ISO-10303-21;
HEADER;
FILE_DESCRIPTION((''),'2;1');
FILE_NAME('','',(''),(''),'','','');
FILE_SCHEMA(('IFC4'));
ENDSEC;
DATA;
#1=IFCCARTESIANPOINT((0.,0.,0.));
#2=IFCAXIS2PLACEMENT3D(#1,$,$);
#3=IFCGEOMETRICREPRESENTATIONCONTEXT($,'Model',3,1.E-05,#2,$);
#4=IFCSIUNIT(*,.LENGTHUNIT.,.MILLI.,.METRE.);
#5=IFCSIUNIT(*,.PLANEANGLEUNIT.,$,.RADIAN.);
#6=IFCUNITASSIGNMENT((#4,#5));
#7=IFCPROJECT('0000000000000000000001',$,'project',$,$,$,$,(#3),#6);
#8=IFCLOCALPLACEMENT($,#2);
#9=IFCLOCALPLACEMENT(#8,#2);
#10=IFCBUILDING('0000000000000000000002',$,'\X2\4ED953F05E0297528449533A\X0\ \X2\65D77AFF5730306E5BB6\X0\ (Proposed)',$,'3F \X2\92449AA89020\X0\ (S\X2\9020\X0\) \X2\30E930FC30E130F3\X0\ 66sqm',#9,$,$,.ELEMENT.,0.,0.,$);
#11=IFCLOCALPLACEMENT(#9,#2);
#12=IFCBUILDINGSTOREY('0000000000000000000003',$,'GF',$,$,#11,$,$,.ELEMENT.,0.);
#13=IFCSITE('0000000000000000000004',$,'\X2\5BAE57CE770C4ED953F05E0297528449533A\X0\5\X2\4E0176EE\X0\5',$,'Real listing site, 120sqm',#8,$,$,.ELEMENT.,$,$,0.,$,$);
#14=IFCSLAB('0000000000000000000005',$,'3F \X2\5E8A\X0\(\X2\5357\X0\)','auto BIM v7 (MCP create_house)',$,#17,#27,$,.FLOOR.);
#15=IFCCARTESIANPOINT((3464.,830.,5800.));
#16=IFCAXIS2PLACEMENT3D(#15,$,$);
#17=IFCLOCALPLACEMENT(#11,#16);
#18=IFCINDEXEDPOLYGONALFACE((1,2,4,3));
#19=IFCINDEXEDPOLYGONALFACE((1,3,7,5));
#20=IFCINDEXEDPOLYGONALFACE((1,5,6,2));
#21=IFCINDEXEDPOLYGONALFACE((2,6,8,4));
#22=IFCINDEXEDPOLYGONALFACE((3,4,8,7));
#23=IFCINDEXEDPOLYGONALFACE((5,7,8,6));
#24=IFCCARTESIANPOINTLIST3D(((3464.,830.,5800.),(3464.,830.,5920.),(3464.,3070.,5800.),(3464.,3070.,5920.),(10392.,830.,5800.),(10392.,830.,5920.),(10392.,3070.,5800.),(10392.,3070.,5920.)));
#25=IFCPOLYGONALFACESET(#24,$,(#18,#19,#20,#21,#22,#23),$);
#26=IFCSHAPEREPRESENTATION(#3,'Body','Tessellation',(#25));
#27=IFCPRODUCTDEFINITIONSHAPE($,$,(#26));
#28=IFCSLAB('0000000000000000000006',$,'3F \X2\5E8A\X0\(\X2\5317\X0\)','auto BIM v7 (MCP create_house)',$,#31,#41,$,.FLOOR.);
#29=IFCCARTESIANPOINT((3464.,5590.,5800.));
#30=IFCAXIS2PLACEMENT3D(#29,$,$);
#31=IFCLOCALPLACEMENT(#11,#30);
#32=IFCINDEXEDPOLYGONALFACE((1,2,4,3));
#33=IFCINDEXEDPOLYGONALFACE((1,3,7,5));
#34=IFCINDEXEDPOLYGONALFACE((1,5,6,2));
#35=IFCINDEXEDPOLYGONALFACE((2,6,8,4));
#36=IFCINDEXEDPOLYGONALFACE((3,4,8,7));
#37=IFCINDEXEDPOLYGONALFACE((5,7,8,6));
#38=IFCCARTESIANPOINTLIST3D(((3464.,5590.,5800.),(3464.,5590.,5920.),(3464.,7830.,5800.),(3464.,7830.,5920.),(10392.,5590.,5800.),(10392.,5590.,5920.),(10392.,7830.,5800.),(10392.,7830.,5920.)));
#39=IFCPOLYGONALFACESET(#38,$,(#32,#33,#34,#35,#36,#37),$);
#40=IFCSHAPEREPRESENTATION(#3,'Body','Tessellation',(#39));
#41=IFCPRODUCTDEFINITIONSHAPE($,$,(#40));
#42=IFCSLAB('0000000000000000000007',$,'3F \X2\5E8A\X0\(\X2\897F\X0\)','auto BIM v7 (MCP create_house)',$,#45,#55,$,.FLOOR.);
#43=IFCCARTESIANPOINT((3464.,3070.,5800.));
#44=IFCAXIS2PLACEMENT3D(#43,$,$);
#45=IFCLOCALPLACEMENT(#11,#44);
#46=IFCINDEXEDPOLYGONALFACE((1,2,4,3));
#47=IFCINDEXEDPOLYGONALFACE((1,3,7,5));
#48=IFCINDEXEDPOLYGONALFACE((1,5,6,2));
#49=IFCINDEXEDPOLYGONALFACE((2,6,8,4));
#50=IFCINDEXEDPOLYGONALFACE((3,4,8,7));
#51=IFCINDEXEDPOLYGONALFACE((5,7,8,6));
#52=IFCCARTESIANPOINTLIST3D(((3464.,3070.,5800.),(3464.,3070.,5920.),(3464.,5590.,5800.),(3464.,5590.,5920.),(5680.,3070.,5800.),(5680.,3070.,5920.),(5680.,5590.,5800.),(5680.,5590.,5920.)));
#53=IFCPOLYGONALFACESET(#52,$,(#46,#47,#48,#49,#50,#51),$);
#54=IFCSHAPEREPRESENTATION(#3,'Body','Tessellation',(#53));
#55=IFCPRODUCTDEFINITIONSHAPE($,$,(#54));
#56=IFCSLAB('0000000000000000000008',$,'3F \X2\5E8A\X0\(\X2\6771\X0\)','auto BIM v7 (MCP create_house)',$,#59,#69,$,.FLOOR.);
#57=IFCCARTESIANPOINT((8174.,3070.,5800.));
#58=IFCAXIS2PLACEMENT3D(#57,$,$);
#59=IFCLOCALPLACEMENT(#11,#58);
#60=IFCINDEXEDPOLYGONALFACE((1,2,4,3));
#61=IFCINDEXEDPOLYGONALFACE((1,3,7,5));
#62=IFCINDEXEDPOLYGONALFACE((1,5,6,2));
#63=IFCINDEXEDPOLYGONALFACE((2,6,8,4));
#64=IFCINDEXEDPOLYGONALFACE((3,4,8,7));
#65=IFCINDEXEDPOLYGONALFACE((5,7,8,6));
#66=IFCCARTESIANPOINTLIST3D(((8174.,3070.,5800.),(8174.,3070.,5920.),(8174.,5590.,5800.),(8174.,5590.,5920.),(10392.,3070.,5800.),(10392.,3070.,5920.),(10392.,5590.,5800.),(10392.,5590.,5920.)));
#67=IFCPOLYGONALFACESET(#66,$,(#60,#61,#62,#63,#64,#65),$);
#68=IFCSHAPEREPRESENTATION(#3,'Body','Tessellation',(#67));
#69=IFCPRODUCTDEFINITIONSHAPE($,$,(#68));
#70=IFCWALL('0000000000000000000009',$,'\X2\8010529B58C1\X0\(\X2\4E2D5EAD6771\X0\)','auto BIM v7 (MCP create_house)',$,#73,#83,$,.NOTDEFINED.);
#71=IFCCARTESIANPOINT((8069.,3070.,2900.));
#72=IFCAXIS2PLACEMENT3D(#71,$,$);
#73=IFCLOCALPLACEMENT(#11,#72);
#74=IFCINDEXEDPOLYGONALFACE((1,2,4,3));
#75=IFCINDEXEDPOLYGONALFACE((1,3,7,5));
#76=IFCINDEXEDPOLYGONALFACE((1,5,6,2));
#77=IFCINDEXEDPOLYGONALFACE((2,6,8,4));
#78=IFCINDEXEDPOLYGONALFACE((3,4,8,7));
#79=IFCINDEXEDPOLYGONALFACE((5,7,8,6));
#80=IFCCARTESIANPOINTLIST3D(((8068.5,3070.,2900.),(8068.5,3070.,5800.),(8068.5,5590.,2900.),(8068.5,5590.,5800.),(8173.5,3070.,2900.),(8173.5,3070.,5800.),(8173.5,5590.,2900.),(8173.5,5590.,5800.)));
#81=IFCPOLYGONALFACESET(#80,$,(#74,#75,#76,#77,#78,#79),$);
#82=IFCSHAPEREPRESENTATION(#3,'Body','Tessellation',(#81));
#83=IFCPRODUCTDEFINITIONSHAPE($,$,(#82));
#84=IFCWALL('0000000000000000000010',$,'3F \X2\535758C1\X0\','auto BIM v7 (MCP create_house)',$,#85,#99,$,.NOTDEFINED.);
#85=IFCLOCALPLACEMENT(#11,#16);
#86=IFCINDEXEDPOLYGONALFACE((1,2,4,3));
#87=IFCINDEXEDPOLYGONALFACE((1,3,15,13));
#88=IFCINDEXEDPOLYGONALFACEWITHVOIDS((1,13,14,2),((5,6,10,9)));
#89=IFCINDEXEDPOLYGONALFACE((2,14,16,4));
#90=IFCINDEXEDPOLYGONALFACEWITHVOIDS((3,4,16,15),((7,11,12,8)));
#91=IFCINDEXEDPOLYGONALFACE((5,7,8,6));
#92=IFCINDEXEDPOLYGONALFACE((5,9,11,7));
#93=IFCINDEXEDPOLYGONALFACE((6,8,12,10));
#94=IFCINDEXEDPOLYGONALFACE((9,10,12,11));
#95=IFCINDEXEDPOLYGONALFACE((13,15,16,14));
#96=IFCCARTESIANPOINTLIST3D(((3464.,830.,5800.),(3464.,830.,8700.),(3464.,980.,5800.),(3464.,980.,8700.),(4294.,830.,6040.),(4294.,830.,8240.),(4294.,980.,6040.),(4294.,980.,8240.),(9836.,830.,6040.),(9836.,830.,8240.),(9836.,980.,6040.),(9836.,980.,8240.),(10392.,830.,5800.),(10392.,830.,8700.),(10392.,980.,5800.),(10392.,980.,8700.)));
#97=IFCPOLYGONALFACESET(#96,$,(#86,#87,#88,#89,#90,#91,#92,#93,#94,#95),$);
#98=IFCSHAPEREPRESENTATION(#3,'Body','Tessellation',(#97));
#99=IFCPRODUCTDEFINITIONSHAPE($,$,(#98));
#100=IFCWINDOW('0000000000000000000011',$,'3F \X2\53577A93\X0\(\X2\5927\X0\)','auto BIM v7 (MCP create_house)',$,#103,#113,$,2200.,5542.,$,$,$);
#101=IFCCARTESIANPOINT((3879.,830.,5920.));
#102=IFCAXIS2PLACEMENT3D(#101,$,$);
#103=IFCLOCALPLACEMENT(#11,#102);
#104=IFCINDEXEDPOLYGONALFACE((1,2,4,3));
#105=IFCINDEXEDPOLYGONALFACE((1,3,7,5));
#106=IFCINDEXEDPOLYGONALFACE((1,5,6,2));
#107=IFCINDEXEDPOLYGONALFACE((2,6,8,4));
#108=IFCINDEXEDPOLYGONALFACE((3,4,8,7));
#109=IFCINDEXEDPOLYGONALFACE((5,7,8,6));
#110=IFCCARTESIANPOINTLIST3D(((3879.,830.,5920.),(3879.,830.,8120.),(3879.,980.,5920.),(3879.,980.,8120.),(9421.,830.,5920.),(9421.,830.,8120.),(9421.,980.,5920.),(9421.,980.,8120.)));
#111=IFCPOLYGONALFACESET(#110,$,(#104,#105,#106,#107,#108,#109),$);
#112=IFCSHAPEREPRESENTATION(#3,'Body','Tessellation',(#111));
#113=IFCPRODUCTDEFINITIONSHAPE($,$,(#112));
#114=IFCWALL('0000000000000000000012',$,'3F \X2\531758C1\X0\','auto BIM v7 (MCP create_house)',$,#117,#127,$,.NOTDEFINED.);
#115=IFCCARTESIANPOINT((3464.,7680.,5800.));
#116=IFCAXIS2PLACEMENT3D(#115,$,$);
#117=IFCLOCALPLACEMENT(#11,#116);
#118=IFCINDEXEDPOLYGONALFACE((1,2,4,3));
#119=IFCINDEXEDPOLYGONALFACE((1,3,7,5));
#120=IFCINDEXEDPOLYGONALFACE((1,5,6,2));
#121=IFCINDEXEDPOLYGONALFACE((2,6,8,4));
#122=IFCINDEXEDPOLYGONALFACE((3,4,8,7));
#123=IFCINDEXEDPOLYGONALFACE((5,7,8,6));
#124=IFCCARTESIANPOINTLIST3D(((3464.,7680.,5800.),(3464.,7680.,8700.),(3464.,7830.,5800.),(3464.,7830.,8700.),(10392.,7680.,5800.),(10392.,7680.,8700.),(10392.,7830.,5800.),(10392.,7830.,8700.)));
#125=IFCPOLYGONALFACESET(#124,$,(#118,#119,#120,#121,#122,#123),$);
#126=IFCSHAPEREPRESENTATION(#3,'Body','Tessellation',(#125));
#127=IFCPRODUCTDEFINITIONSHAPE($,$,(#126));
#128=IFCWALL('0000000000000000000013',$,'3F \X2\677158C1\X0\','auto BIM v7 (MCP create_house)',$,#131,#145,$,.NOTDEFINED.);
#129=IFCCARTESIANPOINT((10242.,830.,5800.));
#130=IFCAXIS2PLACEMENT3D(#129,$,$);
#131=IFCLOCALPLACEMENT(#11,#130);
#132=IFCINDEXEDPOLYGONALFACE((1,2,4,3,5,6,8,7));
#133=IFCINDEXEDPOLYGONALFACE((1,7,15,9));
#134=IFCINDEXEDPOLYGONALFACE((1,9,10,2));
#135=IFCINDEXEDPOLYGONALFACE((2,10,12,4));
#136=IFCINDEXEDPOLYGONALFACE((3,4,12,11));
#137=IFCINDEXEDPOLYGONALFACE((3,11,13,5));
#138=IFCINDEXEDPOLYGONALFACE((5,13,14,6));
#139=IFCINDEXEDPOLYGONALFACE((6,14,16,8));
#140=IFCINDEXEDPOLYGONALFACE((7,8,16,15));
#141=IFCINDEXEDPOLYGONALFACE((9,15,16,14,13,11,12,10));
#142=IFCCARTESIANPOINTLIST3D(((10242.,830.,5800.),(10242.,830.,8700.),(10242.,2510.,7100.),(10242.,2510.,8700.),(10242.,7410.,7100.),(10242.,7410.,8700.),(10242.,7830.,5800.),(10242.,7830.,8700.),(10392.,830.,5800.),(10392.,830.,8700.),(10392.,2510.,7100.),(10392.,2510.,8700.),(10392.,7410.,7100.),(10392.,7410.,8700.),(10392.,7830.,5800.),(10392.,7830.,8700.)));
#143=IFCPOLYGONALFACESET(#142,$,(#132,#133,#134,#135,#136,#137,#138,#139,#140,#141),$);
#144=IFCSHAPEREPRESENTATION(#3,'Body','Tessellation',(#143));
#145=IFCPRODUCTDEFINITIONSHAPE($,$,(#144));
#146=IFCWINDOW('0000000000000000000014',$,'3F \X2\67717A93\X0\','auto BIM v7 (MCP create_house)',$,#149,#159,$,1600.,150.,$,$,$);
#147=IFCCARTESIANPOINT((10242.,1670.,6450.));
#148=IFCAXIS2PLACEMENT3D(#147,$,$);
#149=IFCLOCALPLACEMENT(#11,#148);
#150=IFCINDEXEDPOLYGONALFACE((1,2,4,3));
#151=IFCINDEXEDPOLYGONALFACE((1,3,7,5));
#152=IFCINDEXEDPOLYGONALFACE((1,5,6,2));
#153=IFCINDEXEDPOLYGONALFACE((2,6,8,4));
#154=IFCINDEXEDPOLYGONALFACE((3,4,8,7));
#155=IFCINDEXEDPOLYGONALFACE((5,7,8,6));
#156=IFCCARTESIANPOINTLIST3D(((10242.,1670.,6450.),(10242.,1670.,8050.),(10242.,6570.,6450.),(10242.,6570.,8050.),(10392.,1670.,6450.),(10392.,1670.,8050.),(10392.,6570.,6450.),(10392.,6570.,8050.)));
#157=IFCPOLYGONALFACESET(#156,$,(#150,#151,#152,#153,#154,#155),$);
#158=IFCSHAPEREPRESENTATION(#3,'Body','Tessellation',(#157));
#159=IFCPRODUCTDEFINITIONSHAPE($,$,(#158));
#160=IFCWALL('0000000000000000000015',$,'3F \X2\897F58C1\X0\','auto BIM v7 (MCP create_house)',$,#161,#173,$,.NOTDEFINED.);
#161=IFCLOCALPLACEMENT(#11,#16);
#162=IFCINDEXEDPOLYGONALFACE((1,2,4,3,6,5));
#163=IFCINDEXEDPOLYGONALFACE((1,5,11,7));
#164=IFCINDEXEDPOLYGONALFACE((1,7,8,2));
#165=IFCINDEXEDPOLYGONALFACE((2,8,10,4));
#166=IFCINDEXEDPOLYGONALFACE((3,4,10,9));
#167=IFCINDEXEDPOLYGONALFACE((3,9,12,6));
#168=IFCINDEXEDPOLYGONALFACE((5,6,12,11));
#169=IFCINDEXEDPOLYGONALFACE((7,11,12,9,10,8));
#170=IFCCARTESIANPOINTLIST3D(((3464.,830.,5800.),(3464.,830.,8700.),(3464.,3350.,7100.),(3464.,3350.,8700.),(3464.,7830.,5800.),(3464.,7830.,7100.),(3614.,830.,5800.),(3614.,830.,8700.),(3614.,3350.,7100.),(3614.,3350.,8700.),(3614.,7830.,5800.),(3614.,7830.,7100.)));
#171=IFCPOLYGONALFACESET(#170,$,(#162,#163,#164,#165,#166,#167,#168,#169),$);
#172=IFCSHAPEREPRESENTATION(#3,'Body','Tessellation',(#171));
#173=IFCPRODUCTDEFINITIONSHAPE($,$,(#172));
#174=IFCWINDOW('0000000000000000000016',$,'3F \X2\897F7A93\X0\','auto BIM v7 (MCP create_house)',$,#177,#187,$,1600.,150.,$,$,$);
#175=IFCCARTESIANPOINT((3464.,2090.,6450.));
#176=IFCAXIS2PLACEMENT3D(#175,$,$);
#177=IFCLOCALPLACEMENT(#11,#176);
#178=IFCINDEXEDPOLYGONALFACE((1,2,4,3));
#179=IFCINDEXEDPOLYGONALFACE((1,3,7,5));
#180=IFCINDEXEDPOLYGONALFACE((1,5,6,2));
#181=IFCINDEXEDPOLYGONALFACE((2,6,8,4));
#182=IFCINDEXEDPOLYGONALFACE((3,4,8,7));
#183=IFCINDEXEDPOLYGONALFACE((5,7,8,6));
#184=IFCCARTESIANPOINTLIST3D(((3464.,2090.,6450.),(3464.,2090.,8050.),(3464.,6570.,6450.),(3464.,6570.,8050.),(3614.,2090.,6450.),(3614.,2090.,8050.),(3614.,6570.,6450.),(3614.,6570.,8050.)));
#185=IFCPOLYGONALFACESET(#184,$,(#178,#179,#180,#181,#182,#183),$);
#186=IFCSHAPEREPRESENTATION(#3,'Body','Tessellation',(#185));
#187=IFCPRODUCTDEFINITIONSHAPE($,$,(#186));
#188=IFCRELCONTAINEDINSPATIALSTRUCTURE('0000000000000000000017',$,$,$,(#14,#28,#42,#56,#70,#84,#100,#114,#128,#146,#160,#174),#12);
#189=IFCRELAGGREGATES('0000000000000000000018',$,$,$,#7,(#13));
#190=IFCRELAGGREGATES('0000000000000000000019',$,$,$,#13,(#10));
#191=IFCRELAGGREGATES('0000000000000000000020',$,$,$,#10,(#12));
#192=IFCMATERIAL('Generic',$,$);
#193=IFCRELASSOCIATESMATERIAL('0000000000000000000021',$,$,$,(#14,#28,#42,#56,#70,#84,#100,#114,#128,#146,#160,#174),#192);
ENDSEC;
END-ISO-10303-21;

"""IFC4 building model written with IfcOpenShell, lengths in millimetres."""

from ifc_helpers import new_model, si_unit, frame, frame_2d, origin, place, context, project, spatial, rectangle, extrude, material, element, fill, save


model = new_model("IFC4")

# Units and contexts
model_context = context("Model", 3, precision=1e-05, world=origin())
ifc_project = project(units=[si_unit("LENGTHUNIT", "METRE", prefix="MILLI"), si_unit("PLANEANGLEUNIT", "RADIAN")], contexts=[model_context])

# Site, building, storey
site_placement = place(None, origin())
site = spatial("IfcSite", under=ifc_project, at=site_placement, Name="宮城県仙台市青葉区5丁目5", ObjectType="Real listing site, 120sqm", CompositionType="ELEMENT", RefElevation=0.0)
building_placement = place(site_placement, origin())
building = spatial("IfcBuilding", under=site, at=building_placement, Name="仙台市青葉区 旗竿地の家 (Proposed)", ObjectType="3F 鉄骨造 (S造) ラーメン 66sqm", CompositionType="ELEMENT", ElevationOfRefHeight=0.0, ElevationOfTerrain=0.0)
storey_placement = place(building_placement, origin())
storey = spatial("IfcBuildingStorey", under=building, at=storey_placement, Name="GF", CompositionType="ELEMENT", Elevation=0.0)

# Slabs
ifc_material = material(Name="Generic")
slab_1_placement = place(storey_placement, frame((3464.0, 830.0, 5800.0)))
element("IfcSlab", 1, at=slab_1_placement, inside=storey, material=ifc_material, Name="3F 床(南)", Description="auto BIM v7 (MCP create_house)", PredefinedType="FLOOR", context=model_context, shape_type="SweptSolid", body=[
    extrude(rectangle(XDim=6928.0, YDim=2240.0, at=frame_2d((3464.0, 1120.0))), frame((3464.0, 830.0, 5800.0)), (0.0, 0.0, 1.0), 120.0),
])
slab_2_placement = place(storey_placement, frame((3464.0, 5590.0, 5800.0)))
element("IfcSlab", 2, at=slab_2_placement, inside=storey, material=ifc_material, Name="3F 床(北)", Description="auto BIM v7 (MCP create_house)", PredefinedType="FLOOR", context=model_context, shape_type="SweptSolid", body=[
    extrude(rectangle(XDim=6928.0, YDim=2240.0, at=frame_2d((3464.0, 1120.0))), frame((3464.0, 5590.0, 5800.0)), (0.0, 0.0, 1.0), 120.0),
])
slab_3_placement = place(storey_placement, frame((3464.0, 3070.0, 5800.0)))
element("IfcSlab", 3, at=slab_3_placement, inside=storey, material=ifc_material, Name="3F 床(西)", Description="auto BIM v7 (MCP create_house)", PredefinedType="FLOOR", context=model_context, shape_type="SweptSolid", body=[
    extrude(rectangle(XDim=2216.0, YDim=2520.0, at=frame_2d((1108.0, 1260.0))), frame((3464.0, 3070.0, 5800.0)), (0.0, 0.0, 1.0), 120.0),
])
slab_4_placement = place(storey_placement, frame((8174.0, 3070.0, 5800.0)))
element("IfcSlab", 4, at=slab_4_placement, inside=storey, material=ifc_material, Name="3F 床(東)", Description="auto BIM v7 (MCP create_house)", PredefinedType="FLOOR", context=model_context, shape_type="SweptSolid", body=[
    extrude(rectangle(XDim=2218.0, YDim=2520.0, at=frame_2d((1109.0, 1260.0))), frame((8174.0, 3070.0, 5800.0)), (0.0, 0.0, 1.0), 120.0),
])

# Wall
wall_1_placement = place(storey_placement, frame((8069.0, 3070.0, 2900.0)))
element("IfcWall", 5, at=wall_1_placement, inside=storey, material=ifc_material, Name="耐力壁(中庭東)", Description="auto BIM v7 (MCP create_house)", PredefinedType="NOTDEFINED", context=model_context, shape_type="SweptSolid", body=[
    extrude(rectangle(XDim=105.0, YDim=2520.0, at=frame_2d((52.0, 1260.0))), frame((8069.0, 3070.0, 2900.0)), (0.0, 0.0, 1.0), 2900.0),
])

# Wall, opening, window
wall_2_placement = place(storey_placement, frame((3464.0, 830.0, 5800.0)))
wall_2 = element("IfcWall", 6, at=wall_2_placement, inside=storey, material=ifc_material, Name="3F 南壁", Description="auto BIM v7 (MCP create_house)", PredefinedType="NOTDEFINED", context=model_context, shape_type="SweptSolid", body=[
    extrude(rectangle(XDim=6928.0, YDim=150.0, at=frame_2d((3464.0, 75.0))), frame((3464.0, 830.0, 5800.0)), (0.0, 0.0, 1.0), 2900.0),
])
opening_1_placement = place(storey_placement, frame((3879.0, 830.0, 5920.0)))
opening_1 = element("IfcOpeningElement", 7, at=opening_1_placement, cuts=wall_2, PredefinedType="NOTDEFINED", context=model_context, shape_type="SweptSolid", body=[
    extrude(rectangle(XDim=5542.0, YDim=150.0, at=frame_2d((2771.0, 75.0))), frame((3879.0, 830.0, 5920.0)), (0.0, 0.0, 1.0), 2200.0),
])
window_1_placement = place(storey_placement, frame((3879.0, 830.0, 5920.0)))
window_1 = element("IfcWindow", 8, at=window_1_placement, inside=storey, material=ifc_material, Name="3F 南窓(大)", Description="auto BIM v7 (MCP create_house)", OverallHeight=2200.0, OverallWidth=5542.0, context=model_context, shape_type="SweptSolid", body=[
    extrude(rectangle(XDim=5542.0, YDim=150.0, at=frame_2d((2771.0, 75.0))), frame((3879.0, 830.0, 5920.0)), (0.0, 0.0, 1.0), 2200.0),
])
fill(opening_1, window_1)

# Wall
wall_3_placement = place(storey_placement, frame((3464.0, 7680.0, 5800.0)))
element("IfcWall", 9, at=wall_3_placement, inside=storey, material=ifc_material, Name="3F 北壁", Description="auto BIM v7 (MCP create_house)", PredefinedType="NOTDEFINED", context=model_context, shape_type="SweptSolid", body=[
    extrude(rectangle(XDim=6928.0, YDim=150.0, at=frame_2d((3464.0, 75.0))), frame((3464.0, 7680.0, 5800.0)), (0.0, 0.0, 1.0), 2900.0),
])

# Walls, openings, windows
wall_4_placement = place(storey_placement, frame((10242.0, 830.0, 5800.0)))
wall_4 = element("IfcWall", 10, at=wall_4_placement, inside=storey, material=ifc_material, Name="3F 東壁", Description="auto BIM v7 (MCP create_house)", PredefinedType="NOTDEFINED", context=model_context, shape_type="SweptSolid", body=[
    extrude(rectangle(XDim=150.0, YDim=7000.0, at=frame_2d((75.0, 3500.0))), frame((10242.0, 830.0, 5800.0)), (0.0, 0.0, 1.0), 2900.0),
])
opening_2_placement = place(storey_placement, frame((10242.0, 1670.0, 6450.0)))
opening_2 = element("IfcOpeningElement", 11, at=opening_2_placement, cuts=wall_4, PredefinedType="NOTDEFINED", context=model_context, shape_type="SweptSolid", body=[
    extrude(rectangle(XDim=150.0, YDim=4900.0, at=frame_2d((75.0, 2450.0))), frame((10242.0, 1670.0, 6450.0)), (0.0, 0.0, 1.0), 1600.0),
])
window_2_placement = place(storey_placement, frame((10242.0, 1670.0, 6450.0)))
window_2 = element("IfcWindow", 12, at=window_2_placement, inside=storey, material=ifc_material, Name="3F 東窓", Description="auto BIM v7 (MCP create_house)", OverallHeight=1600.0, OverallWidth=150.0, context=model_context, shape_type="SweptSolid", body=[
    extrude(rectangle(XDim=150.0, YDim=4900.0, at=frame_2d((75.0, 2450.0))), frame((10242.0, 1670.0, 6450.0)), (0.0, 0.0, 1.0), 1600.0),
])
fill(opening_2, window_2)
wall_5_placement = place(storey_placement, frame((3464.0, 830.0, 5800.0)))
wall_5 = element("IfcWall", 13, at=wall_5_placement, inside=storey, material=ifc_material, Name="3F 西壁", Description="auto BIM v7 (MCP create_house)", PredefinedType="NOTDEFINED", context=model_context, shape_type="SweptSolid", body=[
    extrude(rectangle(XDim=150.0, YDim=7000.0, at=frame_2d((75.0, 3500.0))), frame((3464.0, 830.0, 5800.0)), (0.0, 0.0, 1.0), 2900.0),
])
opening_3_placement = place(storey_placement, frame((3464.0, 2090.0, 6450.0)))
opening_3 = element("IfcOpeningElement", 14, at=opening_3_placement, cuts=wall_5, PredefinedType="NOTDEFINED", context=model_context, shape_type="SweptSolid", body=[
    extrude(rectangle(XDim=150.0, YDim=4480.0, at=frame_2d((75.0, 2240.0))), frame((3464.0, 2090.0, 6450.0)), (0.0, 0.0, 1.0), 1600.0),
])
window_3_placement = place(storey_placement, frame((3464.0, 2090.0, 6450.0)))
window_3 = element("IfcWindow", 15, at=window_3_placement, inside=storey, material=ifc_material, Name="3F 西窓", Description="auto BIM v7 (MCP create_house)", OverallHeight=1600.0, OverallWidth=150.0, context=model_context, shape_type="SweptSolid", body=[
    extrude(rectangle(XDim=150.0, YDim=4480.0, at=frame_2d((75.0, 2240.0))), frame((3464.0, 2090.0, 6450.0)), (0.0, 0.0, 1.0), 1600.0),
])
fill(opening_3, window_3)

save(model, "model.ifc")
